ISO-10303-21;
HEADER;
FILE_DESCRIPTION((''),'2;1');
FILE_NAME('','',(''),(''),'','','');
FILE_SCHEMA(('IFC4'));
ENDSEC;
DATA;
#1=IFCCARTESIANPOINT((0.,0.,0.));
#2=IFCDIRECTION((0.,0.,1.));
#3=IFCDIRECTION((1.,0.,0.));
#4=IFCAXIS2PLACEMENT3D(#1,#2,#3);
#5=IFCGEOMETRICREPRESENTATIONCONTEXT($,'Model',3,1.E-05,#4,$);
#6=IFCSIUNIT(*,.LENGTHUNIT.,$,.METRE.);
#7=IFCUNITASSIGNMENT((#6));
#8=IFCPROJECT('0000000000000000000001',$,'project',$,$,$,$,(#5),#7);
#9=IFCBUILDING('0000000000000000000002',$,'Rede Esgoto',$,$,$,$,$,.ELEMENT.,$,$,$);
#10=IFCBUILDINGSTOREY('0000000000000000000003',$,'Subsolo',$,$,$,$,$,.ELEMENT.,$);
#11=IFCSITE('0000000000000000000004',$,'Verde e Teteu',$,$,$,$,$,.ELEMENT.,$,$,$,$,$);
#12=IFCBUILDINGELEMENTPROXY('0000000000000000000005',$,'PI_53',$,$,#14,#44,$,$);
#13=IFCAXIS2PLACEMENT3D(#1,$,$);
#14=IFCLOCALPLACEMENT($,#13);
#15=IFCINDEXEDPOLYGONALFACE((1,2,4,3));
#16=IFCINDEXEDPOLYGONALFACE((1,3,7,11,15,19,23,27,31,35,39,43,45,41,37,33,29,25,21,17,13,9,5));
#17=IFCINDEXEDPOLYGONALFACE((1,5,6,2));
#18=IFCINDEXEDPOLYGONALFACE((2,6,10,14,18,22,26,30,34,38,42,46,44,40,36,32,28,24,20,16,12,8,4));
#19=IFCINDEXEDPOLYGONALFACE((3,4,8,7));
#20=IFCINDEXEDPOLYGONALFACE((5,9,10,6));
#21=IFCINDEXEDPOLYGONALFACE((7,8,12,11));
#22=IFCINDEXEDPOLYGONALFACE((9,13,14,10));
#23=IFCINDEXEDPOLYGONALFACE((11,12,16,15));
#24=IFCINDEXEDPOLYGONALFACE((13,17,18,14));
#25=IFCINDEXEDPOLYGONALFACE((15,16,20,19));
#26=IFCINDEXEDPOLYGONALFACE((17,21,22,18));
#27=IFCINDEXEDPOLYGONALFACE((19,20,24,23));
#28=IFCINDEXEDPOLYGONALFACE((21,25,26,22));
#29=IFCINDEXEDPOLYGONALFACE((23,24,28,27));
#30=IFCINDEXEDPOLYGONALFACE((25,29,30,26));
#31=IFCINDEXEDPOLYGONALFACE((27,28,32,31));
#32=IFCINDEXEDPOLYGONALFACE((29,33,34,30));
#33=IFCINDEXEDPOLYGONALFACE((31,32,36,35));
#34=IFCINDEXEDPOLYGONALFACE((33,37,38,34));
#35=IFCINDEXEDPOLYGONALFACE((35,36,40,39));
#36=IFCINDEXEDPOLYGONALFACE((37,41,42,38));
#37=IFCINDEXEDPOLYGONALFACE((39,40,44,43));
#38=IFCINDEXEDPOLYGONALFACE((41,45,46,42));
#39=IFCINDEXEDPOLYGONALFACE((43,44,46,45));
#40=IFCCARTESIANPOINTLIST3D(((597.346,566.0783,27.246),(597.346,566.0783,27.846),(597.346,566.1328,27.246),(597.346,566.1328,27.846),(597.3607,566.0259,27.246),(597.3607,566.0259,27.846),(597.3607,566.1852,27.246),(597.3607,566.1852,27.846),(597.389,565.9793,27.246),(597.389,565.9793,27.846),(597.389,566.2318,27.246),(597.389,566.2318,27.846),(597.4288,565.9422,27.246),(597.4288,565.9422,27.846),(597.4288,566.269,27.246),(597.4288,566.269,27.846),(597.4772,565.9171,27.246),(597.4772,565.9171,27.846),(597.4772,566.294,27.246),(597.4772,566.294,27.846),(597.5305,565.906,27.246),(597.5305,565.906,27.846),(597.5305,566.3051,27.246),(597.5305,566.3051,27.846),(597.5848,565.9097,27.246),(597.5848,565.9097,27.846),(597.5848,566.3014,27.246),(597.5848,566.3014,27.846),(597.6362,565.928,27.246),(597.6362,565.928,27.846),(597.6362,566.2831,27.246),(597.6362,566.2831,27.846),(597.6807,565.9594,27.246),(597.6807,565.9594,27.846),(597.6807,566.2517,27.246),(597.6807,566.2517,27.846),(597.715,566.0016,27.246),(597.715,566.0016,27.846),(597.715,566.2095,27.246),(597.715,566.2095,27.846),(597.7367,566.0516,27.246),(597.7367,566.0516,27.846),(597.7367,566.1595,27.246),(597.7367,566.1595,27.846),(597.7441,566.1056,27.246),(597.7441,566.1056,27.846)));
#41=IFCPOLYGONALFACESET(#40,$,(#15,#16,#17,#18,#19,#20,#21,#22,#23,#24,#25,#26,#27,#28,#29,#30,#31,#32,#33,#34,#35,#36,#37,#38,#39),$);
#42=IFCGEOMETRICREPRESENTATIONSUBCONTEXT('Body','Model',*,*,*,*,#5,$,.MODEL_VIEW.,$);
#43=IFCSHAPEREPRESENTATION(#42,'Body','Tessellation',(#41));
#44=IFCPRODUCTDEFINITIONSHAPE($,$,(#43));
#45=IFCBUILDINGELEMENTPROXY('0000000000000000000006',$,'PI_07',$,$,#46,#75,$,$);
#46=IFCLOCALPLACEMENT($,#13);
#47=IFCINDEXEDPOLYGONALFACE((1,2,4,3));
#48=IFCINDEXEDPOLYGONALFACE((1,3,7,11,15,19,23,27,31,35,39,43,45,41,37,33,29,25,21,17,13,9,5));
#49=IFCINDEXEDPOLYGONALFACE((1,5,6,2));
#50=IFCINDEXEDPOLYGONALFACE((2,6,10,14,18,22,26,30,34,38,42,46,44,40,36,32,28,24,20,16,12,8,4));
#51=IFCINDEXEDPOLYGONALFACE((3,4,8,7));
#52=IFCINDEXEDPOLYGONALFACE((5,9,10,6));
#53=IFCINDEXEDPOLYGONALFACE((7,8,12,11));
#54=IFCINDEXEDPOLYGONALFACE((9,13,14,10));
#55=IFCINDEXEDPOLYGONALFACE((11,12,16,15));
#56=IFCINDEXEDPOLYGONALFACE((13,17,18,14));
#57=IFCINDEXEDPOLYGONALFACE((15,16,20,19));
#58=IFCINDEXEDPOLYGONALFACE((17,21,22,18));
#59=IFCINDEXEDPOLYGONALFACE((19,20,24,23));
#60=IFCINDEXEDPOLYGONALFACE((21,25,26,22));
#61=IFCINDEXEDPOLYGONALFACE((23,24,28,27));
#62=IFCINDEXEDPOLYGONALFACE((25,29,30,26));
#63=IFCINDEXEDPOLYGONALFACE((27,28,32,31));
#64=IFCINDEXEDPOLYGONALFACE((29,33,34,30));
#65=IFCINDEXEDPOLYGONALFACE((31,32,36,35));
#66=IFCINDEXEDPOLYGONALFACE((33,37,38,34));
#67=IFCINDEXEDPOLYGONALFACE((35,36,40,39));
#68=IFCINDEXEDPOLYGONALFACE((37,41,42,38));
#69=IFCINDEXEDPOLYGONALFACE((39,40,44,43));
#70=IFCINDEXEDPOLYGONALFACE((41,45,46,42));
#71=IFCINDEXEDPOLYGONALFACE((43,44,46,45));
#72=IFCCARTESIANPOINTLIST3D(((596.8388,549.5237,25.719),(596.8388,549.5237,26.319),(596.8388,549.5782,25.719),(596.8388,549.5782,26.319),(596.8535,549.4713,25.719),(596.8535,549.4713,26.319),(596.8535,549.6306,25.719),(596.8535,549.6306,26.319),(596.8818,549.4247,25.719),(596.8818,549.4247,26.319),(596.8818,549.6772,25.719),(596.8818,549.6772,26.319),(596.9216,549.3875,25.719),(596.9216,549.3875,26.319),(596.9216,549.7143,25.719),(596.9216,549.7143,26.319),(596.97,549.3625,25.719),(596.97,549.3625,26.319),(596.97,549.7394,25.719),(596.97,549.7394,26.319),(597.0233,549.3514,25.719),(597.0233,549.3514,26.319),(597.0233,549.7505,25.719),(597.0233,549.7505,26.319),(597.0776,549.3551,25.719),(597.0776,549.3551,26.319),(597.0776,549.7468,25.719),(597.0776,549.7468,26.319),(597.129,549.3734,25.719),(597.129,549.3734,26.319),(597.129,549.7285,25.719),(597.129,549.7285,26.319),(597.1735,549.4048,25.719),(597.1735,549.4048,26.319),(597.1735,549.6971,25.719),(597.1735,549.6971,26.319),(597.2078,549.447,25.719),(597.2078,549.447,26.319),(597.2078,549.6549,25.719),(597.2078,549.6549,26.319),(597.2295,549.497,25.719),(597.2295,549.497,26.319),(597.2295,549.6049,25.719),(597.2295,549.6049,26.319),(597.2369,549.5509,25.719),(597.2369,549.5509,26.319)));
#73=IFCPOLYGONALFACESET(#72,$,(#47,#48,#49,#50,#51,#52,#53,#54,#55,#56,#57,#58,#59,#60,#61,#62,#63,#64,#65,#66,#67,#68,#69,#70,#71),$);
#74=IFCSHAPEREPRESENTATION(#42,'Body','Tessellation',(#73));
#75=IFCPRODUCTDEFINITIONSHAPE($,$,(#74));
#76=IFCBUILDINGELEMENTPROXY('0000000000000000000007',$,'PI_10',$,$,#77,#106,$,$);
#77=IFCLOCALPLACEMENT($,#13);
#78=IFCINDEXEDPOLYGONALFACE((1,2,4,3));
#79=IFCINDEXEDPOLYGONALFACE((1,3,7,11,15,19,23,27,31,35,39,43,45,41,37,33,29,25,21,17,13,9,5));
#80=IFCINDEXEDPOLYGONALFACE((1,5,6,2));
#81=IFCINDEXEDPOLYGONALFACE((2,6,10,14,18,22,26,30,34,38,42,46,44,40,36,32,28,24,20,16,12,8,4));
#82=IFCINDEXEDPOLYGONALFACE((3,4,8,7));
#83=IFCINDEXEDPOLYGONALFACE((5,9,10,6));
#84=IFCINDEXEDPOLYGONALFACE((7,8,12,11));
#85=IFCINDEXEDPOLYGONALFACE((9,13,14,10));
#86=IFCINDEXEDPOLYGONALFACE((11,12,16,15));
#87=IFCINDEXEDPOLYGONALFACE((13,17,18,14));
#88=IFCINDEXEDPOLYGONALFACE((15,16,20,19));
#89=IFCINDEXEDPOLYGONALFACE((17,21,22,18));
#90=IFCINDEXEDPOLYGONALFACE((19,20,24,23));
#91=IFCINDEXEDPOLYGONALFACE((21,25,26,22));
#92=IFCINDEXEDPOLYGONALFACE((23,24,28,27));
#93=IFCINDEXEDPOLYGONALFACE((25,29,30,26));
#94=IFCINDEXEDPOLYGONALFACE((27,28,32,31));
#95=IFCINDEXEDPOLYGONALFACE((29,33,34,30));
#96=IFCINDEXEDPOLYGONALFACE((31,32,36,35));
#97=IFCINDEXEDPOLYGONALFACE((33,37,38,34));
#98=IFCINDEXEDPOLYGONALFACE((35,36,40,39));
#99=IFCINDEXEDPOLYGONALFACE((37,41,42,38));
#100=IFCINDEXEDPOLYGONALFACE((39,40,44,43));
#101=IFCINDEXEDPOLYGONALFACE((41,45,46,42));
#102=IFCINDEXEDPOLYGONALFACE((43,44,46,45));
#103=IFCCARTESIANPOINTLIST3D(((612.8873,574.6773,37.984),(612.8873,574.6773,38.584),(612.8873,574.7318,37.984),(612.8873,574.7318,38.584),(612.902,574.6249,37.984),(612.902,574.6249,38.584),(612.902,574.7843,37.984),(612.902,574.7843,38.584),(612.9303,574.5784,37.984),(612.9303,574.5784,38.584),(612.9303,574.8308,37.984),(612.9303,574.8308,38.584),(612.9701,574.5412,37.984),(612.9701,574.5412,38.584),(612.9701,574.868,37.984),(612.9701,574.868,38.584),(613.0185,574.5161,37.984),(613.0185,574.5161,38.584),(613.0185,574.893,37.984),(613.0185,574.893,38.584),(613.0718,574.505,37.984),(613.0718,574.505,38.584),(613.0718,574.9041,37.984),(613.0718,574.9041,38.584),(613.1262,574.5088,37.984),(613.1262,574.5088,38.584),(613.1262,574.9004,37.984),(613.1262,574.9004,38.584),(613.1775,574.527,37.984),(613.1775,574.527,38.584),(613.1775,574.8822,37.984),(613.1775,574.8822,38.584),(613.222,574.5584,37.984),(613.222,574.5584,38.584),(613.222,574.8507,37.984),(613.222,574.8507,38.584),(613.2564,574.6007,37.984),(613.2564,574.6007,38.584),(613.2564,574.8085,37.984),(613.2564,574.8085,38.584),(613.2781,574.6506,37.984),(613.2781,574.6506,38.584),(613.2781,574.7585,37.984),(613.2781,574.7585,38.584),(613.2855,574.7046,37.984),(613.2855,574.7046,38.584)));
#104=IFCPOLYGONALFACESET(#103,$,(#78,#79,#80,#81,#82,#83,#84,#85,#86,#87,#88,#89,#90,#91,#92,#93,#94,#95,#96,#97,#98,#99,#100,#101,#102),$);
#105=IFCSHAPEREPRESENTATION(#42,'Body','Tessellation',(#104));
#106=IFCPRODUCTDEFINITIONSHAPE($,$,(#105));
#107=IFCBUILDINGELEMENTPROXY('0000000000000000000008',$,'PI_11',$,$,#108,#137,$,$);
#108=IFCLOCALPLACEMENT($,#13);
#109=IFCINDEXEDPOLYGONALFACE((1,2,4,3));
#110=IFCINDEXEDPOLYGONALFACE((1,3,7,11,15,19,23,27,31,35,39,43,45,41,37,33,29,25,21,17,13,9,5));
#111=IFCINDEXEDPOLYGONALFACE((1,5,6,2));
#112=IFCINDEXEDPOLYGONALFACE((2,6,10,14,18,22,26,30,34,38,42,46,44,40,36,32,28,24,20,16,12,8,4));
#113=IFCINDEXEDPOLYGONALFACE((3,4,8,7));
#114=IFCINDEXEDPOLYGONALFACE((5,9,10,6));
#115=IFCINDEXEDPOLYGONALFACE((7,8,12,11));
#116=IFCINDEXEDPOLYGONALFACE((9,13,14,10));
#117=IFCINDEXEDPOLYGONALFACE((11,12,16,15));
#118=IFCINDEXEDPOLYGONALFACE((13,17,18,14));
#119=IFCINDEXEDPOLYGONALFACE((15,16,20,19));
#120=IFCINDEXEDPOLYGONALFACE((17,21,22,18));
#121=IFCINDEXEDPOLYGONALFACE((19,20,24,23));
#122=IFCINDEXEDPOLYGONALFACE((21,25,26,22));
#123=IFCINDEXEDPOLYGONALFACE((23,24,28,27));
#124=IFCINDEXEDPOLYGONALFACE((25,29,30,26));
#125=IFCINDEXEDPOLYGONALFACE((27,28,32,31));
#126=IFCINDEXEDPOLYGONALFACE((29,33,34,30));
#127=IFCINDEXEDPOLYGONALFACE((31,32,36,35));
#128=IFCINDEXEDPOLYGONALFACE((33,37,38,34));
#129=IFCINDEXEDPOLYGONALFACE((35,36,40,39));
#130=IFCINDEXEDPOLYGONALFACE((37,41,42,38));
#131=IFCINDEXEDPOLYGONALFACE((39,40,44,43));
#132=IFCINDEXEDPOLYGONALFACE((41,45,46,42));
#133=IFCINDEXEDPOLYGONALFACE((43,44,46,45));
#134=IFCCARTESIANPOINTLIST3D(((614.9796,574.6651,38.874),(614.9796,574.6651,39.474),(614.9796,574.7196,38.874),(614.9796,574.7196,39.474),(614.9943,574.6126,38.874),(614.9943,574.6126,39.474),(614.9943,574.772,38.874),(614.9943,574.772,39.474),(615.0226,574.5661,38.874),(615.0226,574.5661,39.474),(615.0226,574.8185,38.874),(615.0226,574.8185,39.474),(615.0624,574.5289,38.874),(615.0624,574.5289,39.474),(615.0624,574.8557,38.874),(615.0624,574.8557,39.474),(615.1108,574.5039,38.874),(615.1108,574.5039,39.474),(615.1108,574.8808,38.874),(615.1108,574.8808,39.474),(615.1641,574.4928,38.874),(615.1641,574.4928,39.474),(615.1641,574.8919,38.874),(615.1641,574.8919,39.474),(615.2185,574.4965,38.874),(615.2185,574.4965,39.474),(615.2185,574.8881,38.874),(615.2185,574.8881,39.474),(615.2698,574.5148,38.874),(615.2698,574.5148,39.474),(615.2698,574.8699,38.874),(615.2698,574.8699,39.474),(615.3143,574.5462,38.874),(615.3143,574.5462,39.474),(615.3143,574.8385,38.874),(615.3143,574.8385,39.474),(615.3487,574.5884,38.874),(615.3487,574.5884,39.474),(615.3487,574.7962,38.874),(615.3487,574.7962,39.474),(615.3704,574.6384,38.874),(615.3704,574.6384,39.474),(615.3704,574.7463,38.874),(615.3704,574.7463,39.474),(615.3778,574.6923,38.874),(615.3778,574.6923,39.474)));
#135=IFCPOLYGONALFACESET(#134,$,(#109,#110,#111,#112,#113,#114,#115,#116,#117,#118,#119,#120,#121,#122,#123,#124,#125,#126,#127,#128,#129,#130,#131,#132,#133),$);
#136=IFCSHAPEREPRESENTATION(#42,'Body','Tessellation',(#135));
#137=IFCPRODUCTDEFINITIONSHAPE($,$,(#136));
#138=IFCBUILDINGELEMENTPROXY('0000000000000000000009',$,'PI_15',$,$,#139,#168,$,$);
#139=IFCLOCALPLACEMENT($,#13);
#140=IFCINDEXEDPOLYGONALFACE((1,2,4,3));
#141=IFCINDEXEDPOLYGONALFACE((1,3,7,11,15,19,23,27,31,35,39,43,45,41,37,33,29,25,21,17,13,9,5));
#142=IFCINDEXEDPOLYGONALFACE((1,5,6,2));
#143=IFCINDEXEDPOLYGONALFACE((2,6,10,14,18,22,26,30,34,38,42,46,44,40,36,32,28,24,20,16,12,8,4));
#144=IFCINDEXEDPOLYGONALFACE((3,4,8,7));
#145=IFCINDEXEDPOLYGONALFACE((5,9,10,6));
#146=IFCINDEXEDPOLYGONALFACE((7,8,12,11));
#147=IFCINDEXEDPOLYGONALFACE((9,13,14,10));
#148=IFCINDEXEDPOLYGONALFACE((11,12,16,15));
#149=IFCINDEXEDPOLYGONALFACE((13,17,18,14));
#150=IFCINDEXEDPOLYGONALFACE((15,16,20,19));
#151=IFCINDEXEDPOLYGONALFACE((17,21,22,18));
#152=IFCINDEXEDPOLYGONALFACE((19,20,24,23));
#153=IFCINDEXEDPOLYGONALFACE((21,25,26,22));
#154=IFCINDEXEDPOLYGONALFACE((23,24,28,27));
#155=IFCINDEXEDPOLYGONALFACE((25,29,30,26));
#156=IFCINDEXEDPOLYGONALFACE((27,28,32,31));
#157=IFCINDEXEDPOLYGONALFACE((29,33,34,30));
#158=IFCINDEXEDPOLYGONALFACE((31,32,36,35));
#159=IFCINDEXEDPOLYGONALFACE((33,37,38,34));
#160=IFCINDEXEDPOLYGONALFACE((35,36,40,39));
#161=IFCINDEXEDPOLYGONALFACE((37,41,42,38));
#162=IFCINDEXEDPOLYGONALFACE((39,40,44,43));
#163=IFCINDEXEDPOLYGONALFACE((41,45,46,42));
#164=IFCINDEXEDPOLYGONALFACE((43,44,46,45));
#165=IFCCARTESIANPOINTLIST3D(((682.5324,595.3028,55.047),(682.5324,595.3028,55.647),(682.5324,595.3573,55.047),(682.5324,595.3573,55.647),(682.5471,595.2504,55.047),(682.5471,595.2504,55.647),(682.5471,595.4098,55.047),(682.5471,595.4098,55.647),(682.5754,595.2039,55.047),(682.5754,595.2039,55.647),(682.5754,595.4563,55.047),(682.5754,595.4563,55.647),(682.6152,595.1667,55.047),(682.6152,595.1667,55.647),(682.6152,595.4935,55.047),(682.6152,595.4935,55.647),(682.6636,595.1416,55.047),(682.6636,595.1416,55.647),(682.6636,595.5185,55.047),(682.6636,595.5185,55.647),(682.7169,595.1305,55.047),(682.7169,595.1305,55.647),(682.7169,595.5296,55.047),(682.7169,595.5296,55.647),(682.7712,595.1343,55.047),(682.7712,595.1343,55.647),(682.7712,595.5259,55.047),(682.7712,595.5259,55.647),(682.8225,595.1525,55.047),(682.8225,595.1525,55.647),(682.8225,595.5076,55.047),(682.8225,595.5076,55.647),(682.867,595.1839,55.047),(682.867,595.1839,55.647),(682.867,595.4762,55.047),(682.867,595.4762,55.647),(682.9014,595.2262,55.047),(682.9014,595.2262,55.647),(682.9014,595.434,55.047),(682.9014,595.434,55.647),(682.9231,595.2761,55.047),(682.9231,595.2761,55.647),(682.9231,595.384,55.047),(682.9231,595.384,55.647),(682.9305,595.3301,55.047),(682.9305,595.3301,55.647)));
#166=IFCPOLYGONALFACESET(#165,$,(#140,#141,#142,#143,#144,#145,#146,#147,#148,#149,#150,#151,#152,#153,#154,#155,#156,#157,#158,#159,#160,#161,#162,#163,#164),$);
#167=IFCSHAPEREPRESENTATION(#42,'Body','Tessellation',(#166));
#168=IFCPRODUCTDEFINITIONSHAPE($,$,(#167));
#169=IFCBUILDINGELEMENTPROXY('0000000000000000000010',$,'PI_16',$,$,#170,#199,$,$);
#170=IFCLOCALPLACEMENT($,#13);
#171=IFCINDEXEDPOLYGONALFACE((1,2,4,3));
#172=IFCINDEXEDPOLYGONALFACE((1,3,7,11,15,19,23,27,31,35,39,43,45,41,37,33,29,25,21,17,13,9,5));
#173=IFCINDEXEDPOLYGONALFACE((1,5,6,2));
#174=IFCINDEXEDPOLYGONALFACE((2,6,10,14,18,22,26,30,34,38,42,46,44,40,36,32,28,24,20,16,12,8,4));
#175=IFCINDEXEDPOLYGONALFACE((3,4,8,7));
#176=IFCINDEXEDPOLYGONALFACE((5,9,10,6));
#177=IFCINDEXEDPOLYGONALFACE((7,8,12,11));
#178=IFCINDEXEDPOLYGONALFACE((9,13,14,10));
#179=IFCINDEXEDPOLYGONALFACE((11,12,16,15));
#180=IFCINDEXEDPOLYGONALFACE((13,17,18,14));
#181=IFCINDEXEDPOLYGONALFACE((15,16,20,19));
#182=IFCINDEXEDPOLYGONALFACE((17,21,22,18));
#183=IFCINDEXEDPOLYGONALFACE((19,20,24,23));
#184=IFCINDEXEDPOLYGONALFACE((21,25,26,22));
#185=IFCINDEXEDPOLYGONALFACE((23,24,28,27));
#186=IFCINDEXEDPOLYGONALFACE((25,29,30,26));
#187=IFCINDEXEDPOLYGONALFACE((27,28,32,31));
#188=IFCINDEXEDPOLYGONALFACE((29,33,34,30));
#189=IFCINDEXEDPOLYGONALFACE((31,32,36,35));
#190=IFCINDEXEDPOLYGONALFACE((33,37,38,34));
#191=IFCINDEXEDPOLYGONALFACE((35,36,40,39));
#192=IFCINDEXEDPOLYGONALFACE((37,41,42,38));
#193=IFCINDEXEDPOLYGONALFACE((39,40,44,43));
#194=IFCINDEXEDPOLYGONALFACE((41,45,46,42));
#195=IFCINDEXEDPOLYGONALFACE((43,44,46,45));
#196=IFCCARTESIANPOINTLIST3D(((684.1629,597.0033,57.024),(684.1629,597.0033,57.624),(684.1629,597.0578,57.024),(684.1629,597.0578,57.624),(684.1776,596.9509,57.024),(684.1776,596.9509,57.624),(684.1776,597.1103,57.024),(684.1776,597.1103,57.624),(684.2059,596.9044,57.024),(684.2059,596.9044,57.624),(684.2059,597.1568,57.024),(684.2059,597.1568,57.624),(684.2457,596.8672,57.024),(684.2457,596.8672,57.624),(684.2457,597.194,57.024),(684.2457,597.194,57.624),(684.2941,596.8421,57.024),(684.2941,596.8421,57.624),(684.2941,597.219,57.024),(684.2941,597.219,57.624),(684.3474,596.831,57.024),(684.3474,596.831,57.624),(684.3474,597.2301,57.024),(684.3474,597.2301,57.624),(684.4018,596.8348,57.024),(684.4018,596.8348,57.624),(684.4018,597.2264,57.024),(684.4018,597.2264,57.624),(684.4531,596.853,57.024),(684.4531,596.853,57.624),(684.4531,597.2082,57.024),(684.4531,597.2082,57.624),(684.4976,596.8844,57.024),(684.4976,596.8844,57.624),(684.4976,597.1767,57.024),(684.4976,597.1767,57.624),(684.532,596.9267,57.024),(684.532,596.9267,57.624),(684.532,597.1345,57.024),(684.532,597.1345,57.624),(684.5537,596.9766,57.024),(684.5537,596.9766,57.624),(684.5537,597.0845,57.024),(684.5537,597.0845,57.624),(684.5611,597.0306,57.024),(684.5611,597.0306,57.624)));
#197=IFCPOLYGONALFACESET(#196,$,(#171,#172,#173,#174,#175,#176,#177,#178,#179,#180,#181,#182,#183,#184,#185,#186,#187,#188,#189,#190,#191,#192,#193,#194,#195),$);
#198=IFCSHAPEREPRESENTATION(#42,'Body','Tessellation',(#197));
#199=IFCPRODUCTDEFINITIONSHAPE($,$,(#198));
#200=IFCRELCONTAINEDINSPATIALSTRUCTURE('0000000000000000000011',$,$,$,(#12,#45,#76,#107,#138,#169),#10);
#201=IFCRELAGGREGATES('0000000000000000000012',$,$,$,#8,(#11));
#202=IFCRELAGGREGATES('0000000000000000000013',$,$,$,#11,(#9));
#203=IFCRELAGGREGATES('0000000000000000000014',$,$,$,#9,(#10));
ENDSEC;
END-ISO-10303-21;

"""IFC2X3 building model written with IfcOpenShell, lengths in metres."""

from ifc_helpers import new_model, si_unit, frame, origin_with_axes, origin_2d, place, context, subcontext, project, spatial, circle, extrude, element, save


model = new_model("IFC2X3")

# Units and contexts
model_context = context("Model", 3, precision=1e-05, world=origin_with_axes())
body_context = subcontext(model_context, "Body", "Model", "MODEL_VIEW")
ifc_project = project(units=[si_unit("LENGTHUNIT", "METRE")], contexts=[model_context])

# Site, building, storey
site = spatial("IfcSite", under=ifc_project, Name="Verde e Teteu", CompositionType="ELEMENT")
building = spatial("IfcBuilding", under=site, Name="Rede Esgoto", CompositionType="ELEMENT")
storey = spatial("IfcBuildingStorey", under=building, Name="Subsolo", CompositionType="ELEMENT")

# Building element proxies
proxy_1_placement = place(None, frame((597.5441, 566.1056, 27.246), z_axis=(0.0, 0.0, 1.0), x_axis=(1.0, 0.0, 0.0)))
element("IfcBuildingElementProxy", 1, at=proxy_1_placement, inside=storey, Name="PI_53", context=body_context, shape_type="SweptSolid", body=[
    extrude(circle(Radius=0.2, at=origin_2d()), origin_with_axes(), (0.0, 0.0, 1.0), 0.6),
])
proxy_2_placement = place(None, frame((597.0369, 549.5509, 25.719), z_axis=(0.0, 0.0, 1.0), x_axis=(1.0, 0.0, 0.0)))
element("IfcBuildingElementProxy", 2, at=proxy_2_placement, inside=storey, Name="PI_07", context=body_context, shape_type="SweptSolid", body=[
    extrude(circle(Radius=0.2, at=origin_2d()), origin_with_axes(), (0.0, 0.0, 1.0), 0.6),
])
proxy_3_placement = place(None, frame((613.0855, 574.7046, 37.984), z_axis=(0.0, 0.0, 1.0), x_axis=(1.0, 0.0, 0.0)))
element("IfcBuildingElementProxy", 3, at=proxy_3_placement, inside=storey, Name="PI_10", context=body_context, shape_type="SweptSolid", body=[
    extrude(circle(Radius=0.2, at=origin_2d()), origin_with_axes(), (0.0, 0.0, 1.0), 0.6),
])
proxy_4_placement = place(None, frame((615.1778, 574.6923, 38.874), z_axis=(0.0, 0.0, 1.0), x_axis=(1.0, 0.0, 0.0)))
element("IfcBuildingElementProxy", 4, at=proxy_4_placement, inside=storey, Name="PI_11", context=body_context, shape_type="SweptSolid", body=[
    extrude(circle(Radius=0.2, at=origin_2d()), origin_with_axes(), (0.0, 0.0, 1.0), 0.6),
])
for number, where, z_axis, x_axis, name in (
    (5, (682.7305, 595.3301, 55.047), (0.0, 0.0, 1.0), (1.0, 0.0, 0.0), "PI_15"),
    (6, (684.3611, 597.0306, 57.024), (0.0, 0.0, 1.0), (1.0, 0.0, 0.0), "PI_16"),
):
    element("IfcBuildingElementProxy", number, at=place(None, frame(where, z_axis=z_axis, x_axis=x_axis)), inside=storey, Name=name, context=body_context, shape_type="SweptSolid", body=[
        extrude(circle(Radius=0.2, at=origin_2d()), origin_with_axes(), (0.0, 0.0, 1.0), 0.6),
    ])

save(model, "model.ifc")
